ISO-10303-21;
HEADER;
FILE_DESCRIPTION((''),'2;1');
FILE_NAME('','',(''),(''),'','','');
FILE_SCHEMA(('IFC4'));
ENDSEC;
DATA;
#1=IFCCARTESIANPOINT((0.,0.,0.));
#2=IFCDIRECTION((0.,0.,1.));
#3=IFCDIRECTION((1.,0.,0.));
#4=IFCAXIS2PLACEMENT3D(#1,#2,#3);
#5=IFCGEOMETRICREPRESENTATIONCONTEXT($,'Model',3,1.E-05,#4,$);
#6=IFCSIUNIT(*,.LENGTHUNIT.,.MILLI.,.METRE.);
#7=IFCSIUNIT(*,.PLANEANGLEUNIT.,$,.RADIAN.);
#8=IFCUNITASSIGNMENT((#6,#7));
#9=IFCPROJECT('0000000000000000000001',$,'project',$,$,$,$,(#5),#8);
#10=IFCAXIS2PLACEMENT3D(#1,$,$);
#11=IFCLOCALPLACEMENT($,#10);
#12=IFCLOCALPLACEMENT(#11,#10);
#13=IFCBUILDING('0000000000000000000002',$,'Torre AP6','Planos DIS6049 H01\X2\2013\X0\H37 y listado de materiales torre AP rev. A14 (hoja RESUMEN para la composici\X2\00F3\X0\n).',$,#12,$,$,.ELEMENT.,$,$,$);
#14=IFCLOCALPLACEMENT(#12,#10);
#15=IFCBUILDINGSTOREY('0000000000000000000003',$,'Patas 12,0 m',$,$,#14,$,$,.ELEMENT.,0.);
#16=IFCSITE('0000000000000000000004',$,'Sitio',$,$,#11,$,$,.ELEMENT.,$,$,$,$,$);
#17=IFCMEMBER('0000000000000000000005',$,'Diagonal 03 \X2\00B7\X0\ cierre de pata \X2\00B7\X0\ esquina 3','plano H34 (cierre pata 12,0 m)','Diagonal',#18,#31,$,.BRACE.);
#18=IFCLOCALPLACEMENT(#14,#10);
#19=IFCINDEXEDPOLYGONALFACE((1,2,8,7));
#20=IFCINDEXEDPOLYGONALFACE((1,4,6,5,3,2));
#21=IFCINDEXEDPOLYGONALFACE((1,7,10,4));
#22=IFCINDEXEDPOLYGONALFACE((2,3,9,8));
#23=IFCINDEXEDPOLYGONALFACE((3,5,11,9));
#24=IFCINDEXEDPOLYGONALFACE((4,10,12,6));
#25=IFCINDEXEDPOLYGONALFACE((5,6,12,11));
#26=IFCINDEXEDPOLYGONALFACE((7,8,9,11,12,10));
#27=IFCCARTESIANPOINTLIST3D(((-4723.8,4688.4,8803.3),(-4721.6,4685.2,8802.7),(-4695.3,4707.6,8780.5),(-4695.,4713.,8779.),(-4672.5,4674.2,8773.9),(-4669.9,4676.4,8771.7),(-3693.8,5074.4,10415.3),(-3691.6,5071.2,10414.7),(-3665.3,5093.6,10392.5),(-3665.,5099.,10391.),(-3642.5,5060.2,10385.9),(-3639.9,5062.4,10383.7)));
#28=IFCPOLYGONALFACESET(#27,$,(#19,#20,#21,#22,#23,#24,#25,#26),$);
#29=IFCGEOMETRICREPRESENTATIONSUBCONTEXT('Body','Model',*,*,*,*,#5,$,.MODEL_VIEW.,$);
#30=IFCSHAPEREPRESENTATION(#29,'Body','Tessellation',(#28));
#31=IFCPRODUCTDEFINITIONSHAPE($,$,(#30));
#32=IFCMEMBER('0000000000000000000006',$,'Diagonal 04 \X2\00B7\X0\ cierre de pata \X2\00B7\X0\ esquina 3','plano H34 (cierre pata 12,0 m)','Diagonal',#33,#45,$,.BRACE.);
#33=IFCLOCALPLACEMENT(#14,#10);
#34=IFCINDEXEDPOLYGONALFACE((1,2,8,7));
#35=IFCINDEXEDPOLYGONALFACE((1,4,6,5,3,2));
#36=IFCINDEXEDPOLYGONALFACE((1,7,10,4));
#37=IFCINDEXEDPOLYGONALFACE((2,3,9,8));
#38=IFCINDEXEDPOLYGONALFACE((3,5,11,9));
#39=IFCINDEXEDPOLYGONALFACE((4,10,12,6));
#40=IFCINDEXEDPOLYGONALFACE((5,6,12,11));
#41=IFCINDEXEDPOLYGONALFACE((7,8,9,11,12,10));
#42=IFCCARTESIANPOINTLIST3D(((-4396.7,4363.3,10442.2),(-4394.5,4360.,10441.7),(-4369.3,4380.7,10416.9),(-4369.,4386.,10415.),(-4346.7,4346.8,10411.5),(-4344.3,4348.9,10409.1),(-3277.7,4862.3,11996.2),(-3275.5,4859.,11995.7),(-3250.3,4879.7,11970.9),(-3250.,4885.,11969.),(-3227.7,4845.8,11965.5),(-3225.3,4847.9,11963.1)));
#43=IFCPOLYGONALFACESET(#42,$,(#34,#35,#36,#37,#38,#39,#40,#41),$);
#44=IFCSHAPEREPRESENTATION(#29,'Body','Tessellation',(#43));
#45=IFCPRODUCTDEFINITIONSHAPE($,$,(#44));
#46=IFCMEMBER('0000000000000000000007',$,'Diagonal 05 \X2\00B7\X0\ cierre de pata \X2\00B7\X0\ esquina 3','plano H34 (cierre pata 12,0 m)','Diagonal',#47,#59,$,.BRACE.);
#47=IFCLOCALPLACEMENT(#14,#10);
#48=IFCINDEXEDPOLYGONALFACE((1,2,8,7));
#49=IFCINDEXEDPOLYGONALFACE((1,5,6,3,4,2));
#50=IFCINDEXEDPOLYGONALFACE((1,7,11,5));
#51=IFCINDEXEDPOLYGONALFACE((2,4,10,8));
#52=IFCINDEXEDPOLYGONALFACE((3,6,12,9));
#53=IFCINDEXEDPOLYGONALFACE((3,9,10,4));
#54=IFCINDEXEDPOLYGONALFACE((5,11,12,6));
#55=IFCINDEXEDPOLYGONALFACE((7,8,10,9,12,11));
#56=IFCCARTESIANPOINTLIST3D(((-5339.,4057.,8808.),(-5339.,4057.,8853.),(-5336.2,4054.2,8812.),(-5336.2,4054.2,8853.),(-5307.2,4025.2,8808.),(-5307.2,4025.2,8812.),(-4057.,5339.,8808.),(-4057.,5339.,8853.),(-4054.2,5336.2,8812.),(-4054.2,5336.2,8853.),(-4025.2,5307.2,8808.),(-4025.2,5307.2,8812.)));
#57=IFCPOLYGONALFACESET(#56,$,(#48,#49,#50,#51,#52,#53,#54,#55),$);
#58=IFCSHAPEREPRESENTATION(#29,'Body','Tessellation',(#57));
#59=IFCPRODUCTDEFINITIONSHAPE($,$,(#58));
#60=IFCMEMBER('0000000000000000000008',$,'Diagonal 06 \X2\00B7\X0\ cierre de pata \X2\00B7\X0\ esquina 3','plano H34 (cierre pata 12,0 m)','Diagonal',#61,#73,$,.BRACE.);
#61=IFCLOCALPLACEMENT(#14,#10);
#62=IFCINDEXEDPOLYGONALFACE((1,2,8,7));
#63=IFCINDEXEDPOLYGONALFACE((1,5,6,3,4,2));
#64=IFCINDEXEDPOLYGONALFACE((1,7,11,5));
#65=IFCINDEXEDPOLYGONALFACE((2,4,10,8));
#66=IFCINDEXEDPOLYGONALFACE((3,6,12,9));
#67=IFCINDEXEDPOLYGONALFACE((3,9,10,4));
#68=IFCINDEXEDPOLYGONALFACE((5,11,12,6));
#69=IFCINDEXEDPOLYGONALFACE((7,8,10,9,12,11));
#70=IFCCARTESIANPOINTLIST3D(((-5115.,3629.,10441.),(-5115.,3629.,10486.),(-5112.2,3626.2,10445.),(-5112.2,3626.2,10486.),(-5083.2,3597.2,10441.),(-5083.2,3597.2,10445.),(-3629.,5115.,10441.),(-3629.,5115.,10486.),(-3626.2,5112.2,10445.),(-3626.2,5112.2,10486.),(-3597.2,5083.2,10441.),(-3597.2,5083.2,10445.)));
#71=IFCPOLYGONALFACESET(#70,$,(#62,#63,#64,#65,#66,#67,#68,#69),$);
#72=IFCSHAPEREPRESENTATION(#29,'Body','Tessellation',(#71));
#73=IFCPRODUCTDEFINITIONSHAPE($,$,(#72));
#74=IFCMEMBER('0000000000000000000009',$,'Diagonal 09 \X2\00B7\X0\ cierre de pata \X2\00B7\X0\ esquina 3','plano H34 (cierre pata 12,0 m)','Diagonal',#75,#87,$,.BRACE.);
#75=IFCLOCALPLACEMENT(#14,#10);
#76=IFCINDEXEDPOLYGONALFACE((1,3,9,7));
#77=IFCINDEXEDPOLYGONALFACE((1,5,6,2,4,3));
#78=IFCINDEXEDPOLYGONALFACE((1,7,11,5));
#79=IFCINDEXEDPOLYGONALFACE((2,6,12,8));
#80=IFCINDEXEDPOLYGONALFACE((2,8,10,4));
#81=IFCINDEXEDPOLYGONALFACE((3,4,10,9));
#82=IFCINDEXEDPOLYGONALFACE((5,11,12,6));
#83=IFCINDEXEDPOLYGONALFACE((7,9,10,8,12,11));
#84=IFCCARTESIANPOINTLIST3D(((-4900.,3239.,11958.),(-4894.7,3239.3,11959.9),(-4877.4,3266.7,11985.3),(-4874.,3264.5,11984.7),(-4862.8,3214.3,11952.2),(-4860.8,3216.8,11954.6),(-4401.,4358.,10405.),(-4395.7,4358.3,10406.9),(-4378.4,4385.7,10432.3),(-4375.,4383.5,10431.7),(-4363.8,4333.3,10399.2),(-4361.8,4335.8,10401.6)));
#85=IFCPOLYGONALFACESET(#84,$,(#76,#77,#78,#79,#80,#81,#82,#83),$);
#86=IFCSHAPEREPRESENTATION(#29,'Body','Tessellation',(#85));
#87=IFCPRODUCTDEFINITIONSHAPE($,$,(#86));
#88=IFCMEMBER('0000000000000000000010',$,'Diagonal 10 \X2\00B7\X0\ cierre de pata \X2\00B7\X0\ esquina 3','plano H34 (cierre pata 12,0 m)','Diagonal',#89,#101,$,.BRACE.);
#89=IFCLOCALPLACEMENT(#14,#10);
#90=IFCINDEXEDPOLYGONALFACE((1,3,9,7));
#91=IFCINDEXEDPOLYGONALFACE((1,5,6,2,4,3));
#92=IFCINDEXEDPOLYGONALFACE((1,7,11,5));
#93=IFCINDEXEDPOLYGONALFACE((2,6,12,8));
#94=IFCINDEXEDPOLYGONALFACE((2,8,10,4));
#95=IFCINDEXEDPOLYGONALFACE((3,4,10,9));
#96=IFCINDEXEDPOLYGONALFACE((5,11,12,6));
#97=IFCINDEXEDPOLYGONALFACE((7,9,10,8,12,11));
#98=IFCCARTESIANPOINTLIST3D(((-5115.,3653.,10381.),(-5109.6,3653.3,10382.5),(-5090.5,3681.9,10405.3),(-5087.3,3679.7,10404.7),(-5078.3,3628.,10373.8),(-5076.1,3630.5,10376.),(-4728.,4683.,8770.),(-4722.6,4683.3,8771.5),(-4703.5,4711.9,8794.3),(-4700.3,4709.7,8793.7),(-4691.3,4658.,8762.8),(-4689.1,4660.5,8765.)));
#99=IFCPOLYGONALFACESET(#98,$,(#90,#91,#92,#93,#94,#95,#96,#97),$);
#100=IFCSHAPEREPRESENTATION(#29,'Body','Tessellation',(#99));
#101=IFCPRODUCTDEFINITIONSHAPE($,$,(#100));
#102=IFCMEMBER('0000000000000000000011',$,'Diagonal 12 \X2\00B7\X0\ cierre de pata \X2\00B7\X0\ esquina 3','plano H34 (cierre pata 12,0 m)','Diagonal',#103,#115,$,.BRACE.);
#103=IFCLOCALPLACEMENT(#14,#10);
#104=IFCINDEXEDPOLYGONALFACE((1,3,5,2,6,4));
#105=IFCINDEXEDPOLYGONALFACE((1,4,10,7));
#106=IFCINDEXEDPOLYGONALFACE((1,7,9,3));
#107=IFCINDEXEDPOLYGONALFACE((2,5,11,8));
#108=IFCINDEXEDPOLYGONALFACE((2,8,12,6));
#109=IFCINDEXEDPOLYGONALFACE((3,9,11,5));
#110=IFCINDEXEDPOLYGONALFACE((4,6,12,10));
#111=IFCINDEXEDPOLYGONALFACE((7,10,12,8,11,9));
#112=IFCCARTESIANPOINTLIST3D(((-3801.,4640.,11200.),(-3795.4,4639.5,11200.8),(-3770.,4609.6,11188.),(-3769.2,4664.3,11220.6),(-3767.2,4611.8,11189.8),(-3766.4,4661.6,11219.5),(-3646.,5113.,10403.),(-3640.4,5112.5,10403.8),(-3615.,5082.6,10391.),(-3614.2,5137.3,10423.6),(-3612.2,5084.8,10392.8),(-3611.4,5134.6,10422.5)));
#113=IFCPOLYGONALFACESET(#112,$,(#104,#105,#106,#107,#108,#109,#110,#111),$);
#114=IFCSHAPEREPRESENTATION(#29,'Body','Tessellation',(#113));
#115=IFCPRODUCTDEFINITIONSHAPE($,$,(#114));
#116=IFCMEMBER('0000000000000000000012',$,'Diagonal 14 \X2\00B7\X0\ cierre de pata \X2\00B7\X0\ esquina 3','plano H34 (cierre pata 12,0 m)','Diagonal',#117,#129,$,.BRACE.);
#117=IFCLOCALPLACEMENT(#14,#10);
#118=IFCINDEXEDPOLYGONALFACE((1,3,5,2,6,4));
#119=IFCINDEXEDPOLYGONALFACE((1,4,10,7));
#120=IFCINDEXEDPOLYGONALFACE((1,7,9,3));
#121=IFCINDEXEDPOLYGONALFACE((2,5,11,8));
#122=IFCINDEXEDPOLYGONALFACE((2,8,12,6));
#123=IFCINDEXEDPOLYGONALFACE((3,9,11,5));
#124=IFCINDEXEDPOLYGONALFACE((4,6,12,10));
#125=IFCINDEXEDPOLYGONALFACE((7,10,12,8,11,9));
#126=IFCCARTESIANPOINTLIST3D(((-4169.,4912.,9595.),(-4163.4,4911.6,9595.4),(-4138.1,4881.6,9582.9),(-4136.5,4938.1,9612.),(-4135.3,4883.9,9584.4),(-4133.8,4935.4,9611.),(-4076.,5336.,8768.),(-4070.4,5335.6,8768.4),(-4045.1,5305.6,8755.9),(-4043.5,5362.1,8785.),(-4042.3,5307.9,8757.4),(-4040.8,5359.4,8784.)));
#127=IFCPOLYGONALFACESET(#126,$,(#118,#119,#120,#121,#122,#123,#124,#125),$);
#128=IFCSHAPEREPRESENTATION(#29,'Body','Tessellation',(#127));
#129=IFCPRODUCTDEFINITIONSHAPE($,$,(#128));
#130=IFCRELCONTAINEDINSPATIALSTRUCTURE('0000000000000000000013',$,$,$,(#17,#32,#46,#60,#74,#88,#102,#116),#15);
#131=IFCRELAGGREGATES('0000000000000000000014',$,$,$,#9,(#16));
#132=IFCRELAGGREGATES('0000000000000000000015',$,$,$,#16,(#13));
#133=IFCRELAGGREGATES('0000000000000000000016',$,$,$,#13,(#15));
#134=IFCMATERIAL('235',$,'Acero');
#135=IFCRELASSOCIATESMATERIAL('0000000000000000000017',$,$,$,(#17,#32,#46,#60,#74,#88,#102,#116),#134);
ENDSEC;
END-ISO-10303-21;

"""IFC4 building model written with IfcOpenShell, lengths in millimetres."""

from ifc_helpers import new_model, si_unit, frame, frame_2d, origin, origin_with_axes, place, context, subcontext, project, spatial, l_section, extrude, material, element, save


model = new_model("IFC4")

# Units and contexts
model_context = context("Model", 3, precision=1e-05, world=origin_with_axes())
body_context = subcontext(model_context, "Body", "Model", "MODEL_VIEW")
ifc_project = project(units=[si_unit("LENGTHUNIT", "METRE", prefix="MILLI"), si_unit("PLANEANGLEUNIT", "RADIAN")], contexts=[model_context])

# Site, building, storey
site_placement = place(None, origin())
site = spatial("IfcSite", under=ifc_project, at=site_placement, Name="Sitio", CompositionType="ELEMENT")
building_placement = place(site_placement, origin())
building = spatial("IfcBuilding", under=site, at=building_placement, Name="Torre AP6", Description="Planos DIS6049 H01–H37 y listado de materiales torre AP rev. A14 (hoja RESUMEN para la composición).", CompositionType="ELEMENT")
storey_placement = place(building_placement, origin())
storey = spatial("IfcBuildingStorey", under=building, at=storey_placement, Name="Patas 12,0 m", CompositionType="ELEMENT", Elevation=0.0)

# Members
ifc_material_1 = material(Name="235", Category="Acero")
member_1_placement = place(storey_placement, frame((-3665.0, 5099.0, 10391.0), z_axis=(-0.527793, -0.197794, -0.826022), x_axis=(0.557689, -0.814212, -0.161373)))
element("IfcMember", 1, at=member_1_placement, inside=storey, material=ifc_material_1, Name="Diagonal 03 · cierre de pata · esquina 3", Description="plano H34 (cierre pata 12,0 m)", ObjectType="Diagonal", PredefinedType="BRACE", context=body_context, shape_type="SweptSolid", body=[
    extrude(l_section(Depth=45.0, Width=45.0, Thickness=4.0, at=frame_2d((22.5, 22.5))), None, (0.0, 0.0, 1.0), 1951.5),
])
member_2_placement = place(storey_placement, frame((-3250.0, 4885.0, 11969.0), z_axis=(-0.565463, -0.252159, -0.785281), x_axis=(0.549521, -0.82519, -0.130724)))
element("IfcMember", 2, at=member_2_placement, inside=storey, material=ifc_material_1, Name="Diagonal 04 · cierre de pata · esquina 3", Description="plano H34 (cierre pata 12,0 m)", ObjectType="Diagonal", PredefinedType="BRACE", context=body_context, shape_type="SweptSolid", body=[
    extrude(l_section(Depth=45.0, Width=45.0, Thickness=4.0, at=frame_2d((22.5, 22.5))), None, (0.0, 0.0, 1.0), 1978.9),
])
member_3_placement = place(storey_placement, frame((-4057.0, 5339.0, 8808.0), z_axis=(-0.707107, -0.707107, 0.0), x_axis=(0.707107, -0.707107, 0.0)))
element("IfcMember", 3, at=member_3_placement, inside=storey, material=ifc_material_1, Name="Diagonal 05 · cierre de pata · esquina 3", Description="plano H34 (cierre pata 12,0 m)", ObjectType="Diagonal", PredefinedType="BRACE", context=body_context, shape_type="SweptSolid", body=[
    extrude(l_section(Depth=45.0, Width=45.0, Thickness=4.0, at=frame_2d((22.5, 22.5))), None, (0.0, 0.0, 1.0), 1813.0),
])
member_4_placement = place(storey_placement, frame((-3629.0, 5115.0, 10441.0), z_axis=(-0.707107, -0.707107, 0.0), x_axis=(0.707107, -0.707107, 0.0)))
element("IfcMember", 4, at=member_4_placement, inside=storey, material=ifc_material_1, Name="Diagonal 06 · cierre de pata · esquina 3", Description="plano H34 (cierre pata 12,0 m)", ObjectType="Diagonal", PredefinedType="BRACE", context=body_context, shape_type="SweptSolid", body=[
    extrude(l_section(Depth=45.0, Width=45.0, Thickness=4.0, at=frame_2d((22.5, 22.5))), None, (0.0, 0.0, 1.0), 2101.5),
])
member_5_placement = place(storey_placement, frame((-4401.0, 4358.0, 10405.0), z_axis=(-0.252259, -0.565688, 0.785088), x_axis=(0.826453, -0.547962, -0.129279)))
element("IfcMember", 5, at=member_5_placement, inside=storey, material=ifc_material_1, Name="Diagonal 09 · cierre de pata · esquina 3", Description="plano H34 (cierre pata 12,0 m)", ObjectType="Diagonal", PredefinedType="BRACE", context=body_context, shape_type="SweptSolid", body=[
    extrude(l_section(Depth=45.0, Width=45.0, Thickness=4.0, at=frame_2d((22.5, 22.5))), None, (0.0, 0.0, 1.0), 1978.1),
])
member_6_placement = place(storey_placement, frame((-4728.0, 4683.0, 8770.0), z_axis=(-0.198371, -0.527963, 0.825775), x_axis=(0.815593, -0.556162, -0.15966)))
element("IfcMember", 6, at=member_6_placement, inside=storey, material=ifc_material_1, Name="Diagonal 10 · cierre de pata · esquina 3", Description="plano H34 (cierre pata 12,0 m)", ObjectType="Diagonal", PredefinedType="BRACE", context=body_context, shape_type="SweptSolid", body=[
    extrude(l_section(Depth=45.0, Width=45.0, Thickness=4.0, at=frame_2d((22.5, 22.5))), None, (0.0, 0.0, 1.0), 1950.9),
])
member_7_placement = place(storey_placement, frame((-3646.0, 5113.0, 10403.0), z_axis=(-0.164953, -0.503373, 0.848178), x_axis=(0.688043, -0.674878, -0.266714)))
element("IfcMember", 7, at=member_7_placement, inside=storey, material=ifc_material_1, Name="Diagonal 12 · cierre de pata · esquina 3", Description="plano H34 (cierre pata 12,0 m)", ObjectType="Diagonal", PredefinedType="BRACE", context=body_context, shape_type="SweptSolid", body=[
    extrude(l_section(Depth=45.0, Width=45.0, Thickness=4.0, at=frame_2d((22.5, 22.5))), None, (0.0, 0.0, 1.0), 939.7),
])
member_8_placement = place(storey_placement, frame((-4076.0, 5336.0, 8768.0), z_axis=(-0.099572, -0.453962, 0.88544), x_axis=(0.685585, -0.67623, -0.269603)))
element("IfcMember", 8, at=member_8_placement, inside=storey, material=ifc_material_1, Name="Diagonal 14 · cierre de pata · esquina 3", Description="plano H34 (cierre pata 12,0 m)", ObjectType="Diagonal", PredefinedType="BRACE", context=body_context, shape_type="SweptSolid", body=[
    extrude(l_section(Depth=45.0, Width=45.0, Thickness=4.0, at=frame_2d((22.5, 22.5))), None, (0.0, 0.0, 1.0), 934.0),
])

save(model, "model.ifc")
